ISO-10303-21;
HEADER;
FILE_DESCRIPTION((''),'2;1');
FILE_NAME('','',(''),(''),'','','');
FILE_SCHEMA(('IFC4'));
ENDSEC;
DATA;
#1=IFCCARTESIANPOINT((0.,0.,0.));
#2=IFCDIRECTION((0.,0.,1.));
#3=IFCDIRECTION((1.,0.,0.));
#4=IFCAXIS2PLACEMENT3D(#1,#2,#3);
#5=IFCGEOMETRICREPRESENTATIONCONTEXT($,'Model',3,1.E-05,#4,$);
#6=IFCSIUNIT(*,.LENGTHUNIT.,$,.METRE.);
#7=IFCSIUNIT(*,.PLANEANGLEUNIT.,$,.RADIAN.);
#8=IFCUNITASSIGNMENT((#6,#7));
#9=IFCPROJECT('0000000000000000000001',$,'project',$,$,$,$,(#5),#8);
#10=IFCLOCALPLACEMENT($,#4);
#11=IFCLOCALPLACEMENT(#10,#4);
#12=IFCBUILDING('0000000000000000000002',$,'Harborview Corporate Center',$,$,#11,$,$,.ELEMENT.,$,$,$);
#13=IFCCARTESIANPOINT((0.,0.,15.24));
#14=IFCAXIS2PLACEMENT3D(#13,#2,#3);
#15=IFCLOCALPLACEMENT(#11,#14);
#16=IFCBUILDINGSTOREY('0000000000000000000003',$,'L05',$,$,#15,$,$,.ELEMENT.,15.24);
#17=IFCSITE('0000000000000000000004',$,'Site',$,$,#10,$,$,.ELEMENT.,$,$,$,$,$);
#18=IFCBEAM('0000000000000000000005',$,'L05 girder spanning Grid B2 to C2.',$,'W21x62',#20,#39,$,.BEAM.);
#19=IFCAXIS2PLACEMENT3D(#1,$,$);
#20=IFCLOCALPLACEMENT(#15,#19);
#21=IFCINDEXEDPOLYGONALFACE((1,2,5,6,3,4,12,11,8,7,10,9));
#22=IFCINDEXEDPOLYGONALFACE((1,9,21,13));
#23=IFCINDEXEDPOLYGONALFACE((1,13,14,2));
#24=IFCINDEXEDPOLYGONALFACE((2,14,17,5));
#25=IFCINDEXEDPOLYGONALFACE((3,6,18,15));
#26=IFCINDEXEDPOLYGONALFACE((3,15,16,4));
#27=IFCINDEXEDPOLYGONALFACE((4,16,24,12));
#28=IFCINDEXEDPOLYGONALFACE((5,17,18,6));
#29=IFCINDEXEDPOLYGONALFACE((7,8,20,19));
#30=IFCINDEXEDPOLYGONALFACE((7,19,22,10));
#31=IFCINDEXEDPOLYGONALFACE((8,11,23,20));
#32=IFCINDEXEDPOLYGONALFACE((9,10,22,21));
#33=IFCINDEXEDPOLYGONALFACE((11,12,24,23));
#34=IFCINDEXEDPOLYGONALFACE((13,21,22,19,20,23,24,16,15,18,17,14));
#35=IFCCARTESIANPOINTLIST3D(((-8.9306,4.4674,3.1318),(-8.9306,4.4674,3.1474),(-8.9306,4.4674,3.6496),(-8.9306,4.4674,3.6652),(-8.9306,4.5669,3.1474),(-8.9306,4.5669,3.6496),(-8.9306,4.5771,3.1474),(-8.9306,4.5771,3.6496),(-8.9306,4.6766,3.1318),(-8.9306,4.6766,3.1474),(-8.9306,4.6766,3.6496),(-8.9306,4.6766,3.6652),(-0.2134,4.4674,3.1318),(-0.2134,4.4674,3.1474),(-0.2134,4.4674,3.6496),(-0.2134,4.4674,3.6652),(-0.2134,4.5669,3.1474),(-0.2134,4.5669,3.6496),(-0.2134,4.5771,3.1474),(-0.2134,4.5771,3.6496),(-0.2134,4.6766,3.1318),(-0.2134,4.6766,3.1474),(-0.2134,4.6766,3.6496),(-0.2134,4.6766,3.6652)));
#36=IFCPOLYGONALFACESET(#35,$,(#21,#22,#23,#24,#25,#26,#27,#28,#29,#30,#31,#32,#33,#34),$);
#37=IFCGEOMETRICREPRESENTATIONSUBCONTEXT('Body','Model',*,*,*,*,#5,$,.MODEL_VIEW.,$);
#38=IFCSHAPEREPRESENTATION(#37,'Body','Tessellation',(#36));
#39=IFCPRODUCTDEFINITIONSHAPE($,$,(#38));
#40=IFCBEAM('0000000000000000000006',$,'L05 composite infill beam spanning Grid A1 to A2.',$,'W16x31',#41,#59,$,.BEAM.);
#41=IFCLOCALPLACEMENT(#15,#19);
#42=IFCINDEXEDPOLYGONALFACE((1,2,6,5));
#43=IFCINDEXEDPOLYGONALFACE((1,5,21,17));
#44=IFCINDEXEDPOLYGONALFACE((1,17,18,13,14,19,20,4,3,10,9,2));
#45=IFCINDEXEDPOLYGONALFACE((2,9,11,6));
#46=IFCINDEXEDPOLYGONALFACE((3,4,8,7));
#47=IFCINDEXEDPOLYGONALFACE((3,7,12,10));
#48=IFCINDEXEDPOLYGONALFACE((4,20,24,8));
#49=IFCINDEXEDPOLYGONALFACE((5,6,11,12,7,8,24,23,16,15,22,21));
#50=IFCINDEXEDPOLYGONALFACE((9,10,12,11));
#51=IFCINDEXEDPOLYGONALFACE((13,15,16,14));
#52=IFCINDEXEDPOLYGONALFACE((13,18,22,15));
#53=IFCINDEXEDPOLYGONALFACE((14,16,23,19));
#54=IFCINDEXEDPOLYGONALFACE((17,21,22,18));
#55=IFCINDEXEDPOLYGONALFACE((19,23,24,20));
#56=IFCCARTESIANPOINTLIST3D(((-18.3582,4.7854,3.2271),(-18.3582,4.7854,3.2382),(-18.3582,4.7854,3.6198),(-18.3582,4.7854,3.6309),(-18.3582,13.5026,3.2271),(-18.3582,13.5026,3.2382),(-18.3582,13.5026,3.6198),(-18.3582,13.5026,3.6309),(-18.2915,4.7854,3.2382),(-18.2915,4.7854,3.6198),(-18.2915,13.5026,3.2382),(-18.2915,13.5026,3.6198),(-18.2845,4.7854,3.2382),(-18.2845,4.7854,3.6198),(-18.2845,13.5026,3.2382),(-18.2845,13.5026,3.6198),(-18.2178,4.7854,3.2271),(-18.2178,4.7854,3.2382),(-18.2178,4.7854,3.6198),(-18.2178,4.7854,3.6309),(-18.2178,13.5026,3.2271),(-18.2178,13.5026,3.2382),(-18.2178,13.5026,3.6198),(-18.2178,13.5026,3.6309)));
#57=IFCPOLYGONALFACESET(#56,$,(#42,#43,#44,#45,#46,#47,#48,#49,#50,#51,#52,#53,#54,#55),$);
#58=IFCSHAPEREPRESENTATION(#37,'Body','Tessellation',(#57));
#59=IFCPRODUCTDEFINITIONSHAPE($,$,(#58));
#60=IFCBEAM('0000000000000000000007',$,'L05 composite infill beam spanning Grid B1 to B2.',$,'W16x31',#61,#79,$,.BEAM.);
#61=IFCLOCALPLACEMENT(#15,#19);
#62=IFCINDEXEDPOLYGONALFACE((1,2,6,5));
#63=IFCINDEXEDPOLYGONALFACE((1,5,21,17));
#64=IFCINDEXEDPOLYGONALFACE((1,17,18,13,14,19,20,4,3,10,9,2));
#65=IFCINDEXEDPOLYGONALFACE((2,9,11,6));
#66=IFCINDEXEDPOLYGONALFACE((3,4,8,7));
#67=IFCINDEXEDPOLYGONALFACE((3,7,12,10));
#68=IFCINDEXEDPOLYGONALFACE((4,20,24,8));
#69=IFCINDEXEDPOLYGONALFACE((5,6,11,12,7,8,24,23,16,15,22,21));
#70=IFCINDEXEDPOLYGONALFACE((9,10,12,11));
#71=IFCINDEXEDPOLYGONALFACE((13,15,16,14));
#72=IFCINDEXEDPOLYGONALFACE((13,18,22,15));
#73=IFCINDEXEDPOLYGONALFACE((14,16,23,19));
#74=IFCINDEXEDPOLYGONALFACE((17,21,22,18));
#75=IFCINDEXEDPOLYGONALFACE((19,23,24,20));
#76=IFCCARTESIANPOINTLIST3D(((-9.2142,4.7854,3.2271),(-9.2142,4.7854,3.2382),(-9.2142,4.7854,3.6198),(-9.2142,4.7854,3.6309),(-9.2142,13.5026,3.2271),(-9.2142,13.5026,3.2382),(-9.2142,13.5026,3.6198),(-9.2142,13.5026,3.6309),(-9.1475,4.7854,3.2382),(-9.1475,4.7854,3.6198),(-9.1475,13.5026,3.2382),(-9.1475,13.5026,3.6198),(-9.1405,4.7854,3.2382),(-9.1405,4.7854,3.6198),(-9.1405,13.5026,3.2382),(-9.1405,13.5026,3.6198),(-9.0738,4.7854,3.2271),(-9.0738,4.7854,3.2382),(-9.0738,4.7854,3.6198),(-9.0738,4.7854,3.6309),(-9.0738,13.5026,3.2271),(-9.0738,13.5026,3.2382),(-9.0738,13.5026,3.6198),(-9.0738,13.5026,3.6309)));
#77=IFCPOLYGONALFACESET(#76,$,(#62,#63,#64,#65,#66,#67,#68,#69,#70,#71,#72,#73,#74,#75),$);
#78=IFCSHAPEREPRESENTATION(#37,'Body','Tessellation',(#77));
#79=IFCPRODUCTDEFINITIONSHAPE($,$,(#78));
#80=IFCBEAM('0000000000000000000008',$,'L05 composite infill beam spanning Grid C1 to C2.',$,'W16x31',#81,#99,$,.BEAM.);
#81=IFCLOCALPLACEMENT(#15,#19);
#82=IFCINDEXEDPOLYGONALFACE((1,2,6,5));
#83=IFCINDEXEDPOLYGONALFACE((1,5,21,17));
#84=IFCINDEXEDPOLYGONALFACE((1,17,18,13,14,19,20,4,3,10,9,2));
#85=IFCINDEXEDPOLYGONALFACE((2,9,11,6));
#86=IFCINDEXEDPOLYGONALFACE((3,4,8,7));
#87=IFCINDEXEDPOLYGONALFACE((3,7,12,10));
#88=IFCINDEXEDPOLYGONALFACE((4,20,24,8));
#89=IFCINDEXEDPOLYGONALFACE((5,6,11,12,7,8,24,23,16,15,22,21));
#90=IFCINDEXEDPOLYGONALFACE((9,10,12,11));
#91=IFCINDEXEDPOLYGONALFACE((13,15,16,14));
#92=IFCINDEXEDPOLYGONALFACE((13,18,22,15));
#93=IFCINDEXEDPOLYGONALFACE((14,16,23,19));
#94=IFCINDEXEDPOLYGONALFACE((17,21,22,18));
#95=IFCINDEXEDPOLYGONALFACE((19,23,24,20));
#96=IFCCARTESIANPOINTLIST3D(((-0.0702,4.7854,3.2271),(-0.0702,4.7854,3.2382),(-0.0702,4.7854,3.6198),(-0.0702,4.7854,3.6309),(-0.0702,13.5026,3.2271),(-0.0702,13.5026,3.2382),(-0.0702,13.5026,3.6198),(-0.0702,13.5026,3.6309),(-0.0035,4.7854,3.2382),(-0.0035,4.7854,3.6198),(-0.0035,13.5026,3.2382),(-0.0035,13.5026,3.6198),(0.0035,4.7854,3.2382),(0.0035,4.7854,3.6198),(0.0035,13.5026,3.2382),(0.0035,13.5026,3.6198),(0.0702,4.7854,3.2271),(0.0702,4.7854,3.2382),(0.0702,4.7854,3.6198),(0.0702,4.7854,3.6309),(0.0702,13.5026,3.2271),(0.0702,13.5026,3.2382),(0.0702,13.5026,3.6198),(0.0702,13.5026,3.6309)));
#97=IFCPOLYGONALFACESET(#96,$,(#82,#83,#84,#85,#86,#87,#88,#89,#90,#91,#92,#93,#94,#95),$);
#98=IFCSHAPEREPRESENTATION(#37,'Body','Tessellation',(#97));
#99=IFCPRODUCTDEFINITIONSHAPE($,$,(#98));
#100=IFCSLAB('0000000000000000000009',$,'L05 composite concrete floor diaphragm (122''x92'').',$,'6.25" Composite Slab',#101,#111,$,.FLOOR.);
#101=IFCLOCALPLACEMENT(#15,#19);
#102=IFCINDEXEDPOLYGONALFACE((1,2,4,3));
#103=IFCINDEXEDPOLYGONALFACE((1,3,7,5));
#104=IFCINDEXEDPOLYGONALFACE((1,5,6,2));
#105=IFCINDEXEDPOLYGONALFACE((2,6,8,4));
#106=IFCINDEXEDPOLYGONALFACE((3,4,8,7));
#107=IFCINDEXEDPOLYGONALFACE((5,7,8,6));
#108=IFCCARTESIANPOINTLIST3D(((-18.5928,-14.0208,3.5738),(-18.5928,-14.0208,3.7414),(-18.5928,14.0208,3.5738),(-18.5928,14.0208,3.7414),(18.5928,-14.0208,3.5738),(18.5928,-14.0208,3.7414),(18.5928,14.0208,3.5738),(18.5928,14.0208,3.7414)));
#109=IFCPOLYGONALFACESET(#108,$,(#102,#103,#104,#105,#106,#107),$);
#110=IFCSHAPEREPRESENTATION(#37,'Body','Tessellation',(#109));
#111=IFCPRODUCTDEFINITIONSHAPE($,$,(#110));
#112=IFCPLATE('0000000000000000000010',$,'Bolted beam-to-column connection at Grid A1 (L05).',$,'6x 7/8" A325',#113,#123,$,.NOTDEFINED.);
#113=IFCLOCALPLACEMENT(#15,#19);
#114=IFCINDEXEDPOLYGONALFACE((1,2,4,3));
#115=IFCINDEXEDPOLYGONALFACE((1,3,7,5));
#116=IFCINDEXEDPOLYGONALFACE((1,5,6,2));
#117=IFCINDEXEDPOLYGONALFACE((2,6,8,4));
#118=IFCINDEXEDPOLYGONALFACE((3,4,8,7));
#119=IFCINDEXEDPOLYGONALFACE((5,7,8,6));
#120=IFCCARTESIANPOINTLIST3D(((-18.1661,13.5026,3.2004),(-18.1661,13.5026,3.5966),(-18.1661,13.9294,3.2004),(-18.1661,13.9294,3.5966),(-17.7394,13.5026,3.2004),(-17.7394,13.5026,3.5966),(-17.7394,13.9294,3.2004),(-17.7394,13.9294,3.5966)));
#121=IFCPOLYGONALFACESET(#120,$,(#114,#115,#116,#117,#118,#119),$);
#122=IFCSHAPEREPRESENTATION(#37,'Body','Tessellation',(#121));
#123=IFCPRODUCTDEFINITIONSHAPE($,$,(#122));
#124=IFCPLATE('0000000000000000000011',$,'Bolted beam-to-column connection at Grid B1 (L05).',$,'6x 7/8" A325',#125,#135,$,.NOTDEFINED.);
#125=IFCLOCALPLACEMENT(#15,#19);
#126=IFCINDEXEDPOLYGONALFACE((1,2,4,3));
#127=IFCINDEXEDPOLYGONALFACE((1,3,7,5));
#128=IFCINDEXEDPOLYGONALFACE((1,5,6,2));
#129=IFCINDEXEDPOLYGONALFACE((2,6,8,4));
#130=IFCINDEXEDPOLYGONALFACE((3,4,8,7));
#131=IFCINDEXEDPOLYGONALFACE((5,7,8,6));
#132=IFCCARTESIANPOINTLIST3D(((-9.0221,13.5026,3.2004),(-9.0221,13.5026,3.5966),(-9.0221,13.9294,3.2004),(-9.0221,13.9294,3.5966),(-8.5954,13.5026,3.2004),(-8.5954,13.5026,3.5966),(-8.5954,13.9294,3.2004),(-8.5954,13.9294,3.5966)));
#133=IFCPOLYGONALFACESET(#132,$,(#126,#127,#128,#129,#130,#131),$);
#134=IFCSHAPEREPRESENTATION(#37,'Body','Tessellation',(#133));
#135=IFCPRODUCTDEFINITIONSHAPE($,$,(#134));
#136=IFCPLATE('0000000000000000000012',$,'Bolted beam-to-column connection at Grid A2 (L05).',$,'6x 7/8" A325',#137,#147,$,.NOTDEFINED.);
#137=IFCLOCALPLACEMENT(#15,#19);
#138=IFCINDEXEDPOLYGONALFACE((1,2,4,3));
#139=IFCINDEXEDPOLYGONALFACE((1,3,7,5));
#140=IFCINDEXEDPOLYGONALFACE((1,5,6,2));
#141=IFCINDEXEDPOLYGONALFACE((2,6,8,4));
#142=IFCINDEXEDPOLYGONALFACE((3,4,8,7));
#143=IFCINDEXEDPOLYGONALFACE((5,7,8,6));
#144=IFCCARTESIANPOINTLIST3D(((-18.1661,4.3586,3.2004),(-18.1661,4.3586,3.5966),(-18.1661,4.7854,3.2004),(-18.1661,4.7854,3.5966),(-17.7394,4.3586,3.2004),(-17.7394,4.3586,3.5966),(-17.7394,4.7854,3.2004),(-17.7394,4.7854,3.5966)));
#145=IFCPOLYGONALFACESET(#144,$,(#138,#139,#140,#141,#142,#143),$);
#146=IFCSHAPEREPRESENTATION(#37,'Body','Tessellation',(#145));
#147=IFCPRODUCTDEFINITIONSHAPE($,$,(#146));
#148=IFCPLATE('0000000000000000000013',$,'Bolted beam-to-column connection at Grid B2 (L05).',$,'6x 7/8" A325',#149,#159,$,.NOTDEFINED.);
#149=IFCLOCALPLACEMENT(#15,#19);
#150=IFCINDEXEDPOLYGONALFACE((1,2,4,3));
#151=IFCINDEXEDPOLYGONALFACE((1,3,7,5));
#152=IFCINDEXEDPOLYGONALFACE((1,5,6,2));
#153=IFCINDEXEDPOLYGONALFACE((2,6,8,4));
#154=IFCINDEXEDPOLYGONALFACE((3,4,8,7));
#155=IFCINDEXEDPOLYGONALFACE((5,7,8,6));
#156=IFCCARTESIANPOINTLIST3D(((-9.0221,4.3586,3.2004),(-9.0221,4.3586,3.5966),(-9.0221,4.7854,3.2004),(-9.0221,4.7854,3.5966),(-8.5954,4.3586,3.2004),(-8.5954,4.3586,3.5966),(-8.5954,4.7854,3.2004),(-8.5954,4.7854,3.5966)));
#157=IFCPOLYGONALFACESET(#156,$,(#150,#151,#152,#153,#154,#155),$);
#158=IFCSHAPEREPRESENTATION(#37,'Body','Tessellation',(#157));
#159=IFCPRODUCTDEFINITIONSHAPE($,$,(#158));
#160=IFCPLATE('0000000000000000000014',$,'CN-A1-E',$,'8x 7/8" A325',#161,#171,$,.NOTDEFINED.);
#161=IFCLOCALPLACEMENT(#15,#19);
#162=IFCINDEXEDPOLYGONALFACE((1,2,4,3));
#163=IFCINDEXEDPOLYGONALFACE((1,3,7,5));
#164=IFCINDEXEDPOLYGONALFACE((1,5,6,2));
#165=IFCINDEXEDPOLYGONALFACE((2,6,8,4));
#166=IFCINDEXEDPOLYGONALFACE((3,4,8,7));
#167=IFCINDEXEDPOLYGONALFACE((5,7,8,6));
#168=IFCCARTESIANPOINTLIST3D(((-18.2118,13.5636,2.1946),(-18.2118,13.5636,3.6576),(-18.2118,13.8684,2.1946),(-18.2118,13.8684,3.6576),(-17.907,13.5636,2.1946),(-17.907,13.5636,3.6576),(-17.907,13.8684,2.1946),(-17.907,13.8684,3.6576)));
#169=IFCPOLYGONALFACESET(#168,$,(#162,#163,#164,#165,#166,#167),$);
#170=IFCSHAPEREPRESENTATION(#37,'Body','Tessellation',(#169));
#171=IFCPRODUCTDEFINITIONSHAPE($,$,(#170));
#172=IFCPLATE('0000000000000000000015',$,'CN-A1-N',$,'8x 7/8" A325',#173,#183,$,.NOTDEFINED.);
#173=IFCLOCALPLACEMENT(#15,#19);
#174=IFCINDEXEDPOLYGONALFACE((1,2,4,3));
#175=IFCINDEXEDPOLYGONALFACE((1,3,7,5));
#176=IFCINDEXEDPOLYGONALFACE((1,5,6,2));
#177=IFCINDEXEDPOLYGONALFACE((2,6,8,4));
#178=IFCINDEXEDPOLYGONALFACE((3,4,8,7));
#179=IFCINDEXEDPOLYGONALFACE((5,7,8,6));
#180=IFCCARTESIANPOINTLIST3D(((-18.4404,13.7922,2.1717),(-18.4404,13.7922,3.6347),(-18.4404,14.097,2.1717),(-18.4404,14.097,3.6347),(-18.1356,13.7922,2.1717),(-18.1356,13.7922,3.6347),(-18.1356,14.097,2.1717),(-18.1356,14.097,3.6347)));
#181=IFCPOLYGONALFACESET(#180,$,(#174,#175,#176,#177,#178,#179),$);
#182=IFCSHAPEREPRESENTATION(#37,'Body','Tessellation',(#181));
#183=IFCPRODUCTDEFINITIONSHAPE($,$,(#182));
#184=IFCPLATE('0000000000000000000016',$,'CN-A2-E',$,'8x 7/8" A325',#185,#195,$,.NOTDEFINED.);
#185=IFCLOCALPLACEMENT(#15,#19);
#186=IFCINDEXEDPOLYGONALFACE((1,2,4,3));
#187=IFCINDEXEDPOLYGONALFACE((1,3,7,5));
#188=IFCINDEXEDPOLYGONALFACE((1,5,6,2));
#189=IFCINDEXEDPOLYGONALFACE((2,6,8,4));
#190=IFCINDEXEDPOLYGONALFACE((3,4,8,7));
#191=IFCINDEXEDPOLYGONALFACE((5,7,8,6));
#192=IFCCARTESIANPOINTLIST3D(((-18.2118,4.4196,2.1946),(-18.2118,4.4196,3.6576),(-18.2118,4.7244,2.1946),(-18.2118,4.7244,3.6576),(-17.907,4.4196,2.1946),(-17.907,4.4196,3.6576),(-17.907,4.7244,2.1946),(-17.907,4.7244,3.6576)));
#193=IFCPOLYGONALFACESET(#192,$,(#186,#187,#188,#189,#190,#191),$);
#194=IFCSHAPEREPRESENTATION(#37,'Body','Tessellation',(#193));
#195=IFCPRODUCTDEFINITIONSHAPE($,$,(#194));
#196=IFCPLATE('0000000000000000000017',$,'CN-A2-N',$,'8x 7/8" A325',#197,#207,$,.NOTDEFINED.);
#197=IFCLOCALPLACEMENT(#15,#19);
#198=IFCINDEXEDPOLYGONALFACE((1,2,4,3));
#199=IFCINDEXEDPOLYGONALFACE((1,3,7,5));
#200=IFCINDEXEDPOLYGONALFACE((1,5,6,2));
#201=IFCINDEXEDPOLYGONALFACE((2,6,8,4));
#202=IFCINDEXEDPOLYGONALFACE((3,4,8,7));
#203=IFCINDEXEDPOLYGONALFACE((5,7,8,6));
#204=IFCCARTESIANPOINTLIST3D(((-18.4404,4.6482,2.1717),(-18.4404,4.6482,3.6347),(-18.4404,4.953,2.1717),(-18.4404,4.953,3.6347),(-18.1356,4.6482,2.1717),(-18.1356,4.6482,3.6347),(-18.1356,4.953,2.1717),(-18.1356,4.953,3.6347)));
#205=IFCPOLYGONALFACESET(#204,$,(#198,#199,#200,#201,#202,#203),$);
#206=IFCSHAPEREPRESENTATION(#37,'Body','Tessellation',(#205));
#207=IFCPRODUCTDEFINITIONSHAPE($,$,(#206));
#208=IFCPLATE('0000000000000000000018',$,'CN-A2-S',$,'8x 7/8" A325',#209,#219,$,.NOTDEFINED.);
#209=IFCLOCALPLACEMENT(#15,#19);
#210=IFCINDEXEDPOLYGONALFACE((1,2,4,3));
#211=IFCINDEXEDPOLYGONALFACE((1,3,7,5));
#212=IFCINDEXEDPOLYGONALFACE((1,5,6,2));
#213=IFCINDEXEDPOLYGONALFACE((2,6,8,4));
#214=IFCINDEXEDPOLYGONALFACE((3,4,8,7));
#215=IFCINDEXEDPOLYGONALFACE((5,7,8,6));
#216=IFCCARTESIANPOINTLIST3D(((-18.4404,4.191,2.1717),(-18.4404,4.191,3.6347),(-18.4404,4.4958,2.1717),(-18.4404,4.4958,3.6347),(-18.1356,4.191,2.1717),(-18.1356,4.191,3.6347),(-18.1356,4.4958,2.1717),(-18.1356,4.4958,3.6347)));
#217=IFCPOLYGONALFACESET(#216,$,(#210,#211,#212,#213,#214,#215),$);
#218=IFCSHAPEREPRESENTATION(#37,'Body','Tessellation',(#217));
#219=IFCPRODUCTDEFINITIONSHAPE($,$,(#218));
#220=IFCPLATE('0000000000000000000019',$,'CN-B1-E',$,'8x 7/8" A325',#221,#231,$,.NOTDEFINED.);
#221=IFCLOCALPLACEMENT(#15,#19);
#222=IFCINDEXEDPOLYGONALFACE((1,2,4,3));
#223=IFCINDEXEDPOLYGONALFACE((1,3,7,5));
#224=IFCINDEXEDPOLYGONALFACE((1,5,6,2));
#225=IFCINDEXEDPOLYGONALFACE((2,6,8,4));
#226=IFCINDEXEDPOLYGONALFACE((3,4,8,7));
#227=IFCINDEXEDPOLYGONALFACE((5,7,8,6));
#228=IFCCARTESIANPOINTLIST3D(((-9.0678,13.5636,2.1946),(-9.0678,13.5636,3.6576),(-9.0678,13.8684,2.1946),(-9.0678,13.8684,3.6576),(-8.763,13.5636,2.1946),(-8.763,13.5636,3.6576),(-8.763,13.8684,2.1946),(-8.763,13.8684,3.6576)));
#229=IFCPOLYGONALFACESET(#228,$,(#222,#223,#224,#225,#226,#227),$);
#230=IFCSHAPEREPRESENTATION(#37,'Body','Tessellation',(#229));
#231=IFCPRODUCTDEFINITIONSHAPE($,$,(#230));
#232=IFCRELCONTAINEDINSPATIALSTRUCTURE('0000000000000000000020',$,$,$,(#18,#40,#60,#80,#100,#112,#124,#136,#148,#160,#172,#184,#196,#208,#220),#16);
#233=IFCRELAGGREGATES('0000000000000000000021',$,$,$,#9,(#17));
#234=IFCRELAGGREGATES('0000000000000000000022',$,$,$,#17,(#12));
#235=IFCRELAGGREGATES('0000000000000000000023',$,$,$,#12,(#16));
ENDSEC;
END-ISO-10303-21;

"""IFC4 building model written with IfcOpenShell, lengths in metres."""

from ifc_helpers import new_model, si_unit, frame, origin_with_axes, place, context, subcontext, project, spatial, rectangle, i_section, extrude, element, save


model = new_model("IFC4")

# Units and contexts
model_context = context("Model", 3, precision=1e-05, world=origin_with_axes())
body_context = subcontext(model_context, "Body", "Model", "MODEL_VIEW")
ifc_project = project(units=[si_unit("LENGTHUNIT", "METRE"), si_unit("PLANEANGLEUNIT", "RADIAN")], contexts=[model_context])

# Site, building, storey
site_placement = place(None, origin_with_axes())
site = spatial("IfcSite", under=ifc_project, at=site_placement, Name="Site", CompositionType="ELEMENT")
building_placement = place(site_placement, origin_with_axes())
building = spatial("IfcBuilding", under=site, at=building_placement, Name="Harborview Corporate Center", CompositionType="ELEMENT")
storey_placement = place(building_placement, frame((0.0, 0.0, 15.24), z_axis=(0.0, 0.0, 1.0), x_axis=(1.0, 0.0, 0.0)))
storey = spatial("IfcBuildingStorey", under=building, at=storey_placement, Name="L05", CompositionType="ELEMENT", Elevation=15.24)

# Beams
beam_1_placement = place(storey_placement, frame((-8.9306, 4.572, 3.3985), z_axis=(1.0, 0.0, 0.0), x_axis=(0.0, 1.0, 0.0)))
element("IfcBeam", 1, at=beam_1_placement, inside=storey, Name="L05 girder spanning Grid B2 to C2.", ObjectType="W21x62", PredefinedType="BEAM", context=body_context, shape_type="SweptSolid", body=[
    extrude(i_section(OverallWidth=0.2093, OverallDepth=0.5334, WebThickness=0.0102, FlangeThickness=0.0156), origin_with_axes(), (0.0, 0.0, 1.0), 8.7173),
])
for number, where, z_axis, x_axis, name in (
    (2, (-18.288, 4.7854, 3.429), (0.0, 1.0, 0.0), (-1.0, 0.0, 0.0), "L05 composite infill beam spanning Grid A1 to A2."),
    (3, (-9.144, 4.7854, 3.429), (0.0, 1.0, 0.0), (-1.0, 0.0, 0.0), "L05 composite infill beam spanning Grid B1 to B2."),
    (4, (0.0, 4.7854, 3.429), (0.0, 1.0, 0.0), (-1.0, 0.0, 0.0), "L05 composite infill beam spanning Grid C1 to C2."),
):
    element("IfcBeam", number, at=place(storey_placement, frame(where, z_axis=z_axis, x_axis=x_axis)), inside=storey, Name=name, ObjectType="W16x31", PredefinedType="BEAM", context=body_context, shape_type="SweptSolid", body=[
        extrude(i_section(OverallWidth=0.1405, OverallDepth=0.4039, WebThickness=0.007, FlangeThickness=0.0112), origin_with_axes(), (0.0, 0.0, 1.0), 8.7173),
    ])

# Slab
slab_placement = place(storey_placement, frame((0.0, 0.0, 3.5738), z_axis=(0.0, 0.0, 1.0), x_axis=(1.0, 0.0, 0.0)))
element("IfcSlab", 5, at=slab_placement, inside=storey, Name="L05 composite concrete floor diaphragm (122'x92').", ObjectType="6.25\" Composite Slab", PredefinedType="FLOOR", context=body_context, shape_type="SweptSolid", body=[
    extrude(rectangle(XDim=37.1856, YDim=28.0416), origin_with_axes(), (0.0, 0.0, 1.0), 0.1676),
])

# Plates
plate_1_placement = place(storey_placement, frame((-17.9527, 13.716, 3.2004), z_axis=(0.0, 0.0, 1.0), x_axis=(1.0, 0.0, 0.0)))
element("IfcPlate", 6, at=plate_1_placement, inside=storey, Name="Bolted beam-to-column connection at Grid A1 (L05).", ObjectType="6x 7/8\" A325", PredefinedType="NOTDEFINED", context=body_context, shape_type="SweptSolid", body=[
    extrude(rectangle(XDim=0.4267, YDim=0.4267), origin_with_axes(), (0.0, 0.0, 1.0), 0.3962),
])
plate_2_placement = place(storey_placement, frame((-8.8087, 13.716, 3.2004), z_axis=(0.0, 0.0, 1.0), x_axis=(1.0, 0.0, 0.0)))
element("IfcPlate", 7, at=plate_2_placement, inside=storey, Name="Bolted beam-to-column connection at Grid B1 (L05).", ObjectType="6x 7/8\" A325", PredefinedType="NOTDEFINED", context=body_context, shape_type="SweptSolid", body=[
    extrude(rectangle(XDim=0.4267, YDim=0.4267), origin_with_axes(), (0.0, 0.0, 1.0), 0.3962),
])
plate_3_placement = place(storey_placement, frame((-17.9527, 4.572, 3.2004), z_axis=(0.0, 0.0, 1.0), x_axis=(1.0, 0.0, 0.0)))
element("IfcPlate", 8, at=plate_3_placement, inside=storey, Name="Bolted beam-to-column connection at Grid A2 (L05).", ObjectType="6x 7/8\" A325", PredefinedType="NOTDEFINED", context=body_context, shape_type="SweptSolid", body=[
    extrude(rectangle(XDim=0.4267, YDim=0.4267), origin_with_axes(), (0.0, 0.0, 1.0), 0.3962),
])
plate_4_placement = place(storey_placement, frame((-8.8087, 4.572, 3.2004), z_axis=(0.0, 0.0, 1.0), x_axis=(1.0, 0.0, 0.0)))
element("IfcPlate", 9, at=plate_4_placement, inside=storey, Name="Bolted beam-to-column connection at Grid B2 (L05).", ObjectType="6x 7/8\" A325", PredefinedType="NOTDEFINED", context=body_context, shape_type="SweptSolid", body=[
    extrude(rectangle(XDim=0.4267, YDim=0.4267), origin_with_axes(), (0.0, 0.0, 1.0), 0.3962),
])
for number, where, z_axis, x_axis, name in (
    (10, (-18.0594, 13.716, 2.1946), (0.0, 0.0, 1.0), (1.0, 0.0, 0.0), "CN-A1-E"),
    (11, (-18.288, 13.9446, 2.1717), (0.0, 0.0, 1.0), (1.0, 0.0, 0.0), "CN-A1-N"),
    (12, (-18.0594, 4.572, 2.1946), (0.0, 0.0, 1.0), (1.0, 0.0, 0.0), "CN-A2-E"),
    (13, (-18.288, 4.8006, 2.1717), (0.0, 0.0, 1.0), (1.0, 0.0, 0.0), "CN-A2-N"),
    (14, (-18.288, 4.3434, 2.1717), (0.0, 0.0, 1.0), (1.0, 0.0, 0.0), "CN-A2-S"),
    (15, (-8.9154, 13.716, 2.1946), (0.0, 0.0, 1.0), (1.0, 0.0, 0.0), "CN-B1-E"),
):
    element("IfcPlate", number, at=place(storey_placement, frame(where, z_axis=z_axis, x_axis=x_axis)), inside=storey, Name=name, ObjectType="8x 7/8\" A325", PredefinedType="NOTDEFINED", context=body_context, shape_type="SweptSolid", body=[
        extrude(rectangle(XDim=0.3048, YDim=0.3048), origin_with_axes(), (0.0, 0.0, 1.0), 1.463),
    ])

save(model, "model.ifc")
